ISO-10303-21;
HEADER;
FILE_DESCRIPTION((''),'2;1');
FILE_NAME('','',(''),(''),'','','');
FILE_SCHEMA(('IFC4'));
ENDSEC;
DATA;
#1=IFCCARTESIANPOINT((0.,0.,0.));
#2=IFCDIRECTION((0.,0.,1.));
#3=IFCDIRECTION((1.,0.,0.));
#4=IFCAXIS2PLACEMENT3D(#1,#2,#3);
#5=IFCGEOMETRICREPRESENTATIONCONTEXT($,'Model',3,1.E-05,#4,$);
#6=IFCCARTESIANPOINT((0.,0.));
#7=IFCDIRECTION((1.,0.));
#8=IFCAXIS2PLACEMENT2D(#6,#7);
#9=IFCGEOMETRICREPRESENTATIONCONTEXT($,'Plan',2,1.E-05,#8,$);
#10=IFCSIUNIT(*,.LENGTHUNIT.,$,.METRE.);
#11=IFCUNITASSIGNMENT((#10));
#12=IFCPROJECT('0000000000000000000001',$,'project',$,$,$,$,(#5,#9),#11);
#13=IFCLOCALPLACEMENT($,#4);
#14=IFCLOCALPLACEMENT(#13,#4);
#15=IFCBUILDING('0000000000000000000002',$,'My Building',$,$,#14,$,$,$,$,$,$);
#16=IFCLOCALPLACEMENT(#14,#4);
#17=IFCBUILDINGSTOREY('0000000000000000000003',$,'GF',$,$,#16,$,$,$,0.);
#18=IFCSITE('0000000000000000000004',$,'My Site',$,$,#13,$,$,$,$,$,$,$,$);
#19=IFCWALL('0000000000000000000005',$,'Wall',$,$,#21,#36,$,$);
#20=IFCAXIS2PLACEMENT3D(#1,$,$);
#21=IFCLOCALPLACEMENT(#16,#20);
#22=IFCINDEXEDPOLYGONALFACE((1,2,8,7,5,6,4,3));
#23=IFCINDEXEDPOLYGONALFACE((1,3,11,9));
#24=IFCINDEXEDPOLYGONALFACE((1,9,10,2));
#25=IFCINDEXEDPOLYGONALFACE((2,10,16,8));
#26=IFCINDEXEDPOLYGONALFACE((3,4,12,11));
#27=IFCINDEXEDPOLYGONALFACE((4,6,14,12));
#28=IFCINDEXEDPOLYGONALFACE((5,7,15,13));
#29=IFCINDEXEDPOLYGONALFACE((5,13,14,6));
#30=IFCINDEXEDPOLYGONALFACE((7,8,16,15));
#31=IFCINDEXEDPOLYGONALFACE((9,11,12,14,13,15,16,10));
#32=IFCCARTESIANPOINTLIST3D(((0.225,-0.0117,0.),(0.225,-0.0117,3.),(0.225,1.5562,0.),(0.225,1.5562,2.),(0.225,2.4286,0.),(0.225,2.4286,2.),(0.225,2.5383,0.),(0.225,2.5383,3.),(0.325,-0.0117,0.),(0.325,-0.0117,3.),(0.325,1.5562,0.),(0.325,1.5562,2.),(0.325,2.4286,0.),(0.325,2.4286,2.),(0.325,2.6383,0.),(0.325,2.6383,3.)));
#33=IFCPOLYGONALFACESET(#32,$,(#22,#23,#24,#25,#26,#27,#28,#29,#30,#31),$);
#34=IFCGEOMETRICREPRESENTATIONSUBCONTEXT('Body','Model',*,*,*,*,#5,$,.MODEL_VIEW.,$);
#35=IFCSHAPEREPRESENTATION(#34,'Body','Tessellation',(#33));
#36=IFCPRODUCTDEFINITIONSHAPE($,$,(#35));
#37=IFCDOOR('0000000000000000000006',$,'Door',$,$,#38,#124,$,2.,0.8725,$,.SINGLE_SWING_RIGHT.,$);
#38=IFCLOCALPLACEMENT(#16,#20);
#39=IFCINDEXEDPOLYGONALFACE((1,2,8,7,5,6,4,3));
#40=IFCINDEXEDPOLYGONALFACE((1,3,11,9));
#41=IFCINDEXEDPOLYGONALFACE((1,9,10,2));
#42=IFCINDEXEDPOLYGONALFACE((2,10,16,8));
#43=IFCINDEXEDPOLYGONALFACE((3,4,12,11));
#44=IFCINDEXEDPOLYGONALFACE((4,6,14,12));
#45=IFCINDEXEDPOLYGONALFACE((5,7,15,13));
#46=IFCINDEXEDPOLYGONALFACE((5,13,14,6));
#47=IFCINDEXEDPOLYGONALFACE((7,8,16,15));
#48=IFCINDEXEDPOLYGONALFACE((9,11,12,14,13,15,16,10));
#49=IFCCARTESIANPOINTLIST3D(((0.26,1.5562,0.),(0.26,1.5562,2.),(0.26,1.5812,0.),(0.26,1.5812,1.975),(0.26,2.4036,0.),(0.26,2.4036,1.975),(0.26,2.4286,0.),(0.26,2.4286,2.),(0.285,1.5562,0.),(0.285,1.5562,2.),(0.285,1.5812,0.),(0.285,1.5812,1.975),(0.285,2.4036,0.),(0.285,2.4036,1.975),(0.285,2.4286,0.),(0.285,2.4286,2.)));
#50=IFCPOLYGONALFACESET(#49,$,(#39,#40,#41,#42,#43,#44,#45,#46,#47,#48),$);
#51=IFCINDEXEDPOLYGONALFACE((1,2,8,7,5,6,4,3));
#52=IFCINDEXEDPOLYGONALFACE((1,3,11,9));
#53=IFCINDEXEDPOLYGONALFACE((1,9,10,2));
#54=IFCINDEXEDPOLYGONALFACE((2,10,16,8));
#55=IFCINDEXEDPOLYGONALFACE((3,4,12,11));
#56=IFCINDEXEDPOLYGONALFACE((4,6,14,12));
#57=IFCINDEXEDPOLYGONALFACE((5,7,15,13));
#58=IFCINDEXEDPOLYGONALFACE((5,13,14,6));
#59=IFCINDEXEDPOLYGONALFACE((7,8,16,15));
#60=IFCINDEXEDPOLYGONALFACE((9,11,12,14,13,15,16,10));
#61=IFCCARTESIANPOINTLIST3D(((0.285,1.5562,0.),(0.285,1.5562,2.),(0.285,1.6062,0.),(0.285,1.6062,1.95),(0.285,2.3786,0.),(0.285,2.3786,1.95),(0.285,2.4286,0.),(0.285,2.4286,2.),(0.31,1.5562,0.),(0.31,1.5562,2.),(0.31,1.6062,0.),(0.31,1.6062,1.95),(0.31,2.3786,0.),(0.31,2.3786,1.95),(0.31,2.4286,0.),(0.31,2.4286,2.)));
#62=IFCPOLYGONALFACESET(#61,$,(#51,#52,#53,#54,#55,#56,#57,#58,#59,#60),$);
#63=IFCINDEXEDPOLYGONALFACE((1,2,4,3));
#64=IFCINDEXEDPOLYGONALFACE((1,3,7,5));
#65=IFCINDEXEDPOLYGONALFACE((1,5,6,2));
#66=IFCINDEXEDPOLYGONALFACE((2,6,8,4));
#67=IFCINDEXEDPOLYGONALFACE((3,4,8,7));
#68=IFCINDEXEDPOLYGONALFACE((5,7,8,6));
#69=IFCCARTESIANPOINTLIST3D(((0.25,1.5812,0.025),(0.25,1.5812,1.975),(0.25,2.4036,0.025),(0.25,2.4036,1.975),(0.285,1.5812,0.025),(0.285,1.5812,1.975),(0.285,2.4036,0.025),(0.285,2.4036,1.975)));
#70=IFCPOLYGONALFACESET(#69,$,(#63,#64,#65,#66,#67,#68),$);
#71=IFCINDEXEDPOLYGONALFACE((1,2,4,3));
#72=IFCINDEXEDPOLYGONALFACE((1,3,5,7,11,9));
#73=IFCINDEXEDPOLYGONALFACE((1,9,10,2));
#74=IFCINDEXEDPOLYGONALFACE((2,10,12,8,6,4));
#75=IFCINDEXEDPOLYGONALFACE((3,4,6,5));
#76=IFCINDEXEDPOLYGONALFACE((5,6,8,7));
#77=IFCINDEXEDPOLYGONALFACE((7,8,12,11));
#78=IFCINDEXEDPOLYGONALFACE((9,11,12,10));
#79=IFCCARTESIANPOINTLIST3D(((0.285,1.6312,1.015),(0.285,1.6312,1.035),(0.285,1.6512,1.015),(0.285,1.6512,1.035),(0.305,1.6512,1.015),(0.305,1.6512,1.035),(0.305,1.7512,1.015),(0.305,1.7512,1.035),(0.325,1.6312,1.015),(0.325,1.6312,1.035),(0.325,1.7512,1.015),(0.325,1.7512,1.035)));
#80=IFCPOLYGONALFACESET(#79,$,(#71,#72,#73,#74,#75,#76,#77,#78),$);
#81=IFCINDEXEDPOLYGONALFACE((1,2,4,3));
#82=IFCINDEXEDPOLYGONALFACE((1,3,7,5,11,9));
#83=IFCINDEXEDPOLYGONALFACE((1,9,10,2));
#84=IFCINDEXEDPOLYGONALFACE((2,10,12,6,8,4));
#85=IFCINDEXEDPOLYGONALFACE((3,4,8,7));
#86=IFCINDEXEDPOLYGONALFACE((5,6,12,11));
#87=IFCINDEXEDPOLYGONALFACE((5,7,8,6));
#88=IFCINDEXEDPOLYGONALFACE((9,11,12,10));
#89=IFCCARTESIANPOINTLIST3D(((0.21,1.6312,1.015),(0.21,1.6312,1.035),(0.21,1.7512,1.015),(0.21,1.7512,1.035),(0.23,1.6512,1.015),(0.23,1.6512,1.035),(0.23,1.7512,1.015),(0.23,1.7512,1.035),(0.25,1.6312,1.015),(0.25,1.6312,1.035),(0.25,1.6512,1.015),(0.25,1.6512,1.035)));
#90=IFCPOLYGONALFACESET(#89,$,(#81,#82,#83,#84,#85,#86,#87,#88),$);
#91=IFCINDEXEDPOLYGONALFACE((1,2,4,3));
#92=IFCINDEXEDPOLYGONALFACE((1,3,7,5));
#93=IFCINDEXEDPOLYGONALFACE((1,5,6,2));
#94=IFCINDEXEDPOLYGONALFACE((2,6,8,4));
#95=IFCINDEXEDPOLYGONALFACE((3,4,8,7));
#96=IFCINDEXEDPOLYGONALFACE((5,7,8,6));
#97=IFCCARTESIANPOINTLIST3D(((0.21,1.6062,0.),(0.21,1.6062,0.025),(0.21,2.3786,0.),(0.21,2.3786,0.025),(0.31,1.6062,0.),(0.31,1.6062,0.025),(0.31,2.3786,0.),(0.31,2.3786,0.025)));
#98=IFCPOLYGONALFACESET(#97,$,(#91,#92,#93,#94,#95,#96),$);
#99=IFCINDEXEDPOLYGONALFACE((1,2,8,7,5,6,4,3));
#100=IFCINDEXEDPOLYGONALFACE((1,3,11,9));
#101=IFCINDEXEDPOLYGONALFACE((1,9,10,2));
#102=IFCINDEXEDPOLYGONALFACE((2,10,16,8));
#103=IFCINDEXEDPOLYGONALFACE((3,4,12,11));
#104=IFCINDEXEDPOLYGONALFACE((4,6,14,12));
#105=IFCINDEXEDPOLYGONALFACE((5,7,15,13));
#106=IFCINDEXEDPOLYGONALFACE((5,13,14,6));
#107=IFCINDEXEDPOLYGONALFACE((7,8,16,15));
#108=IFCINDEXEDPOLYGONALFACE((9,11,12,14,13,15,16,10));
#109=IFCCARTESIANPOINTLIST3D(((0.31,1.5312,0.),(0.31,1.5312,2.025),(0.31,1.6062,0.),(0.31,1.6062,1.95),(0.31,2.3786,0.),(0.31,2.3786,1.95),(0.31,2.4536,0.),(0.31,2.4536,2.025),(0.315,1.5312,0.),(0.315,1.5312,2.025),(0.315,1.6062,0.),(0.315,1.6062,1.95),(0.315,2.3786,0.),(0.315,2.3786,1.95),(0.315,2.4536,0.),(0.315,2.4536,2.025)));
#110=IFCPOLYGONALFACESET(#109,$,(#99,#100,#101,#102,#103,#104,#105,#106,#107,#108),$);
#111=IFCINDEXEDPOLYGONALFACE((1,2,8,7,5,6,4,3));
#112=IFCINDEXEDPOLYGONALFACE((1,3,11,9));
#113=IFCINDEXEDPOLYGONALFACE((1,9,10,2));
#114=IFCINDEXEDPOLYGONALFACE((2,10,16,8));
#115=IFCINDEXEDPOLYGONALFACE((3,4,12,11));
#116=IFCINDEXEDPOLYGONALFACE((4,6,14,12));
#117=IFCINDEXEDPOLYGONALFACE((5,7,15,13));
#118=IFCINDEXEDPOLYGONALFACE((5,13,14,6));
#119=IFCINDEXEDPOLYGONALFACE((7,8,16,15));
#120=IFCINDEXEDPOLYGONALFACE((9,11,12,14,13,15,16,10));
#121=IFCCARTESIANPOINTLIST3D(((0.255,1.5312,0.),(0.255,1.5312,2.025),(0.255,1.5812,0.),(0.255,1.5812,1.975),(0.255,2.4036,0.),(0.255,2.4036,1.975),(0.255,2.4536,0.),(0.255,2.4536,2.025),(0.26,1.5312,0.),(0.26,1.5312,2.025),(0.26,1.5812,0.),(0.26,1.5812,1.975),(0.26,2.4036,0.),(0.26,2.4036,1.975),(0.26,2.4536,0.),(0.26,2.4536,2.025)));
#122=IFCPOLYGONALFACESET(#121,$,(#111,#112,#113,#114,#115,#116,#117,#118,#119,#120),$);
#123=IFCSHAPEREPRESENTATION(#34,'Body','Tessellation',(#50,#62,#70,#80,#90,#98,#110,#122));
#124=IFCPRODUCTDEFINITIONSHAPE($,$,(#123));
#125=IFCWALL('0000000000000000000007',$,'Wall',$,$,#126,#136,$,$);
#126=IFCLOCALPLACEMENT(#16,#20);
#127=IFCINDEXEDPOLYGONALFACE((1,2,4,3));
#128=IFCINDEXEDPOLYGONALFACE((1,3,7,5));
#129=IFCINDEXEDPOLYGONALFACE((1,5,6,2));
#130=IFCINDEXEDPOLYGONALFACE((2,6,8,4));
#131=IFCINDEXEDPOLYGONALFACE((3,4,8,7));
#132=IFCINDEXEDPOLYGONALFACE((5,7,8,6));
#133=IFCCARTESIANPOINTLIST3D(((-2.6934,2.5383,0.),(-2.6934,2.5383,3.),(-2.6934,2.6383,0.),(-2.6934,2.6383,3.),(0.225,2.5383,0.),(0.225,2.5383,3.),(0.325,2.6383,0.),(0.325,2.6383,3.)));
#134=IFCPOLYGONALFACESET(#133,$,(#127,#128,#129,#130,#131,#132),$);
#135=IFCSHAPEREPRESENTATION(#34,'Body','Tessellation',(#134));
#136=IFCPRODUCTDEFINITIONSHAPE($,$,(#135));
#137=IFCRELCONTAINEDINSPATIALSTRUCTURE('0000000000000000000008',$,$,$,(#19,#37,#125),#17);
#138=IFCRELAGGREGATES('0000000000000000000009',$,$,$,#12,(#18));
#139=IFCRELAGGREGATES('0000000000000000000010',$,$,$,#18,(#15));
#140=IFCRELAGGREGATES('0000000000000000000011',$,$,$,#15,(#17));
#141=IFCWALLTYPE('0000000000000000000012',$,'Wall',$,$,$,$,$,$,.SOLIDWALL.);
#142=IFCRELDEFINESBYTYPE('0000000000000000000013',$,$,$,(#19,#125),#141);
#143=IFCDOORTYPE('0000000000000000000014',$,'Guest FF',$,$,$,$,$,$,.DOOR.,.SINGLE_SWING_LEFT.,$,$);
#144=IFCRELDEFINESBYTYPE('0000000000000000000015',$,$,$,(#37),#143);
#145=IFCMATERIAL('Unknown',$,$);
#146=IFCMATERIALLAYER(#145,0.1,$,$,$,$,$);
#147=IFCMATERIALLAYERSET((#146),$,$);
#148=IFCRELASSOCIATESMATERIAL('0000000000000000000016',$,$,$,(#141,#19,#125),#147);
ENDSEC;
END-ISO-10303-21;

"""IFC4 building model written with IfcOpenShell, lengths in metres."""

from ifc_helpers import new_model, entity, si_unit, frame, origin_with_axes, origin_2d_with_axis, place, context, subcontext, project, spatial, line, indexed_curve, outline, extrude, shape, source, transform, mapped, material, layer, layer_set, layer_usage, type_object, type_shapes, element, fill, save


model = new_model("IFC4")

# Units and contexts
model_context = context("Model", 3, precision=1e-05, world=origin_with_axes())
plan_context = context("Plan", 2, precision=1e-05, world=origin_2d_with_axis())
body_context_1 = subcontext(model_context, "Body", "Model", "MODEL_VIEW")
body_context_2 = subcontext(plan_context, "Body", "Plan", "PLAN_VIEW")
ifc_project = project(units=[si_unit("LENGTHUNIT", "METRE")], contexts=[model_context, plan_context])

# Site, building, storey
site_placement = place(None, origin_with_axes())
site = spatial("IfcSite", under=ifc_project, at=site_placement, Name="My Site")
building_placement = place(site_placement, origin_with_axes())
building = spatial("IfcBuilding", under=site, at=building_placement, Name="My Building")
storey_placement = place(building_placement, origin_with_axes())
storey = spatial("IfcBuildingStorey", under=building, at=storey_placement, Name="GF", Elevation=0.0)

# Shared definitions
ifc_material = material(Name="Unknown")

# Shared definitions
ifc_layer_1 = layer(ifc_material, 0.1)
ifc_layer_set_1 = layer_set([ifc_layer_1])
wall_type = type_object("IfcWallType", Name="Wall", PredefinedType="SOLIDWALL", material=ifc_layer_set_1)

# Wall, opening, door
ifc_layer_usage_1 = layer_usage(ifc_layer_set_1, "AXIS2", "POSITIVE", 0.0)
wall_1_placement = place(storey_placement, frame((0.325, -0.0117, 0.0), z_axis=(0.0, 0.0, 1.0), x_axis=(0.0, 1.0, 0.0)))
wall_1 = element("IfcWall", 1, at=wall_1_placement, inside=storey, type_object=wall_type, material=ifc_layer_usage_1, Name="Wall", context=body_context_1, shape_type="SweptSolid", body=[
    extrude(outline(indexed_curve([(0.0, 0.0), (0.0, 0.1), (2.55, 0.1), (2.65, 0.0)], segments=[line(1, 2, 3, 4, 1)])), origin_with_axes(), (0.0, 0.0, 1.0), 3.0),
])
shared_shape_1 = source(origin_with_axes(), body_context_1, "Body", "SweptSolid", [
    extrude(outline(indexed_curve([(0.0, 0.0), (0.8725, 0.0), (0.8725, 2.0), (0.0, 2.0)], segments=[line(1, 2, 3, 4, 1)])), frame((0.0, -0.6, 0.0), z_axis=(0.0, -1.0, 0.0), x_axis=(1.0, 0.0, 0.0)), (0.0, 0.0, -1.0), 1.2),
])
opening_1_placement = place(wall_1_placement, frame((1.5679, 0.015, 0.0), z_axis=(0.0, 0.0, 1.0), x_axis=(1.0, 0.0, 0.0)))
opening_1 = element("IfcOpeningElement", 2, at=opening_1_placement, cuts=wall_1, PredefinedType="OPENING", context=body_context_1, shape_type="MappedRepresentation", body=[
    mapped(shared_shape_1, transform((0.0, 0.0, 0.0), x_axis=(1.0, 0.0, 0.0), y_axis=(0.0, 1.0, 0.0), z_axis=(0.0, 0.0, 1.0), scale=1.0)),
])
door_type_1 = type_object("IfcDoorType", Name="Guest FF", OperationType="SINGLE_SWING_LEFT", PredefinedType="DOOR")
shared_shape_2 = source(origin_with_axes(), body_context_1, "Body", "SweptSolid", [
    extrude(outline(indexed_curve([(0.0, 0.0), (0.0, 2.0), (0.8725, 2.0), (0.8725, 0.0), (0.8475, 0.0), (0.8475, 1.975), (0.025, 1.975), (0.025, 0.0)], segments=[line(1, 2, 3, 4, 5, 6, 7, 8, 1)])), frame((0.0, 0.025, 0.0), z_axis=(0.0, -1.0, 0.0), x_axis=(1.0, 0.0, 0.0)), (0.0, 0.0, -1.0), 0.025),
    extrude(outline(indexed_curve([(0.0, 0.0), (0.0, 2.0), (0.8725, 2.0), (0.8725, 0.0), (0.8225, 0.0), (0.8225, 1.95), (0.05, 1.95), (0.05, 0.0)], segments=[line(1, 2, 3, 4, 5, 6, 7, 8, 1)])), frame((0.0, 0.0, 0.0), z_axis=(0.0, -1.0, 0.0), x_axis=(1.0, 0.0, 0.0)), (0.0, 0.0, -1.0), 0.025),
    extrude(outline(indexed_curve([(0.0, 0.0), (0.8225, 0.0), (0.8225, 0.035), (0.0, 0.035)], segments=[line(1, 2, 3, 4, 1)])), frame((0.025, 0.025, 0.025), z_axis=(0.0, 0.0, 1.0), x_axis=(1.0, 0.0, 0.0)), (0.0, 0.0, 1.0), 1.95),
    extrude(outline(indexed_curve([(0.0, 0.0), (0.0, -0.04), (0.12, -0.04), (0.12, -0.02), (0.02, -0.02), (0.02, 0.0)], segments=[line(1, 2, 3, 4, 5, 6, 1)])), frame((0.075, 0.025, 1.015), z_axis=(0.0, 0.0, 1.0), x_axis=(1.0, 0.0, 0.0)), (0.0, 0.0, 1.0), 0.02),
    extrude(outline(indexed_curve([(0.0, 0.0), (0.0, 0.04), (0.12, 0.04), (0.12, 0.02), (0.02, 0.02), (0.02, 0.0)], segments=[line(1, 2, 3, 4, 5, 6, 1)])), frame((0.075, 0.06, 1.015), z_axis=(0.0, 0.0, 1.0), x_axis=(1.0, 0.0, 0.0)), (0.0, 0.0, 1.0), 0.02),
    extrude(outline(indexed_curve([(0.0, 0.0), (0.7725, 0.0), (0.7725, 0.1), (0.0, 0.1)], segments=[line(1, 2, 3, 4, 1)])), frame((0.05, 0.0, 0.0), z_axis=(0.0, 0.0, 1.0), x_axis=(1.0, 0.0, 0.0)), (0.0, 0.0, 1.0), 0.025),
    extrude(outline(indexed_curve([(0.0, 0.0), (0.0, 2.025), (0.9225, 2.025), (0.9225, 0.0), (0.8475, 0.0), (0.8475, 1.95), (0.075, 1.95), (0.075, 0.0)], segments=[line(1, 2, 3, 4, 5, 6, 7, 8, 1)])), frame((-0.025, -0.005, 0.0), z_axis=(0.0, -1.0, 0.0), x_axis=(1.0, 0.0, 0.0)), (0.0, 0.0, -1.0), 0.005),
    extrude(outline(indexed_curve([(0.0, 0.0), (0.0, 2.025), (0.9225, 2.025), (0.9225, 0.0), (0.8725, 0.0), (0.8725, 1.975), (0.05, 1.975), (0.05, 0.0)], segments=[line(1, 2, 3, 4, 5, 6, 7, 8, 1)])), frame((-0.025, 0.05, 0.0), z_axis=(0.0, -1.0, 0.0), x_axis=(1.0, 0.0, 0.0)), (0.0, 0.0, -1.0), 0.005),
])
shared_shape_3 = source(origin_with_axes(), body_context_2, "Body", "Curve2D", [
    entity("IfcIndexedPolyCurve", entity("IfcCartesianPointList2D", [[0.0, 0.0], [0.0, 0.05], [0.025, 0.05], [0.025, 0.025], [0.05, 0.025], [0.05, 0.0]]), [entity("IfcLineIndex", [1, 2, 3, 4, 5, 6, 1])]),
    entity("IfcIndexedPolyCurve", entity("IfcCartesianPointList2D", [[0.8725, 0.0], [0.8725, 0.05], [0.8475, 0.05], [0.8475, 0.025], [0.8225, 0.025], [0.8225, 0.0]]), [entity("IfcLineIndex", [1, 2, 3, 4, 5, 6, 1])]),
    entity("IfcTrimmedCurve", entity("IfcEllipse", entity("IfcAxis2Placement2D", entity("IfcCartesianPoint", [0.8125, 0.05]), entity("IfcDirection", [1.0, 0.0])), 0.7875, 0.8225), [entity("IfcCartesianPoint", [0.8125, 0.8725])], [entity("IfcCartesianPoint", [0.025, 0.05])], True, "CARTESIAN"),
    entity("IfcIndexedPolyCurve", entity("IfcCartesianPointList2D", [[0.8475, 0.05], [0.8125, 0.05], [0.8125, 0.8725], [0.8475, 0.8725]]), [entity("IfcLineIndex", [1, 2, 3, 4, 1])]),
])
type_shapes(door_type_1, [shared_shape_2, shared_shape_3])
door_1_placement = place(opening_1_placement, frame((0.0, 0.0, 0.0), z_axis=(0.0, 0.0, 1.0), x_axis=(1.0, 0.0, 0.0)))
door_1 = element("IfcDoor", 3, at=door_1_placement, inside=storey, type_object=door_type_1, Name="Door", OperationType="SINGLE_SWING_RIGHT", OverallHeight=2.0, OverallWidth=0.8725, shapes=[
    shape(body_context_1, "Body", "MappedRepresentation", [mapped(shared_shape_2, transform((0.0, 0.0, 0.0), x_axis=(1.0, 0.0, 0.0), y_axis=(0.0, 1.0, 0.0), z_axis=(0.0, 0.0, 1.0), scale=1.0))]),
    shape(body_context_2, "Body", "MappedRepresentation", [mapped(shared_shape_3, transform((0.0, 0.0, 0.0), x_axis=(1.0, 0.0, 0.0), y_axis=(0.0, 1.0, 0.0), z_axis=(0.0, 0.0, 1.0), scale=1.0))]),
])
fill(opening_1, door_1)

# Wall
ifc_layer_usage_2 = layer_usage(ifc_layer_set_1, "AXIS2", "POSITIVE", 0.0)
wall_2_placement = place(storey_placement, frame((0.325, 2.6383, 0.0), z_axis=(0.0, 0.0, 1.0), x_axis=(-1.0, 0.0, 0.0)))
element("IfcWall", 4, at=wall_2_placement, inside=storey, type_object=wall_type, material=ifc_layer_usage_2, Name="Wall", context=body_context_1, shape_type="SweptSolid", body=[
    extrude(outline(indexed_curve([(0.0, 0.0), (0.1, 0.1), (3.0184, 0.1), (3.0184, 0.0)], segments=[line(1, 2, 3, 4, 1)])), origin_with_axes(), (0.0, 0.0, 1.0), 3.0),
])

save(model, "model.ifc")
